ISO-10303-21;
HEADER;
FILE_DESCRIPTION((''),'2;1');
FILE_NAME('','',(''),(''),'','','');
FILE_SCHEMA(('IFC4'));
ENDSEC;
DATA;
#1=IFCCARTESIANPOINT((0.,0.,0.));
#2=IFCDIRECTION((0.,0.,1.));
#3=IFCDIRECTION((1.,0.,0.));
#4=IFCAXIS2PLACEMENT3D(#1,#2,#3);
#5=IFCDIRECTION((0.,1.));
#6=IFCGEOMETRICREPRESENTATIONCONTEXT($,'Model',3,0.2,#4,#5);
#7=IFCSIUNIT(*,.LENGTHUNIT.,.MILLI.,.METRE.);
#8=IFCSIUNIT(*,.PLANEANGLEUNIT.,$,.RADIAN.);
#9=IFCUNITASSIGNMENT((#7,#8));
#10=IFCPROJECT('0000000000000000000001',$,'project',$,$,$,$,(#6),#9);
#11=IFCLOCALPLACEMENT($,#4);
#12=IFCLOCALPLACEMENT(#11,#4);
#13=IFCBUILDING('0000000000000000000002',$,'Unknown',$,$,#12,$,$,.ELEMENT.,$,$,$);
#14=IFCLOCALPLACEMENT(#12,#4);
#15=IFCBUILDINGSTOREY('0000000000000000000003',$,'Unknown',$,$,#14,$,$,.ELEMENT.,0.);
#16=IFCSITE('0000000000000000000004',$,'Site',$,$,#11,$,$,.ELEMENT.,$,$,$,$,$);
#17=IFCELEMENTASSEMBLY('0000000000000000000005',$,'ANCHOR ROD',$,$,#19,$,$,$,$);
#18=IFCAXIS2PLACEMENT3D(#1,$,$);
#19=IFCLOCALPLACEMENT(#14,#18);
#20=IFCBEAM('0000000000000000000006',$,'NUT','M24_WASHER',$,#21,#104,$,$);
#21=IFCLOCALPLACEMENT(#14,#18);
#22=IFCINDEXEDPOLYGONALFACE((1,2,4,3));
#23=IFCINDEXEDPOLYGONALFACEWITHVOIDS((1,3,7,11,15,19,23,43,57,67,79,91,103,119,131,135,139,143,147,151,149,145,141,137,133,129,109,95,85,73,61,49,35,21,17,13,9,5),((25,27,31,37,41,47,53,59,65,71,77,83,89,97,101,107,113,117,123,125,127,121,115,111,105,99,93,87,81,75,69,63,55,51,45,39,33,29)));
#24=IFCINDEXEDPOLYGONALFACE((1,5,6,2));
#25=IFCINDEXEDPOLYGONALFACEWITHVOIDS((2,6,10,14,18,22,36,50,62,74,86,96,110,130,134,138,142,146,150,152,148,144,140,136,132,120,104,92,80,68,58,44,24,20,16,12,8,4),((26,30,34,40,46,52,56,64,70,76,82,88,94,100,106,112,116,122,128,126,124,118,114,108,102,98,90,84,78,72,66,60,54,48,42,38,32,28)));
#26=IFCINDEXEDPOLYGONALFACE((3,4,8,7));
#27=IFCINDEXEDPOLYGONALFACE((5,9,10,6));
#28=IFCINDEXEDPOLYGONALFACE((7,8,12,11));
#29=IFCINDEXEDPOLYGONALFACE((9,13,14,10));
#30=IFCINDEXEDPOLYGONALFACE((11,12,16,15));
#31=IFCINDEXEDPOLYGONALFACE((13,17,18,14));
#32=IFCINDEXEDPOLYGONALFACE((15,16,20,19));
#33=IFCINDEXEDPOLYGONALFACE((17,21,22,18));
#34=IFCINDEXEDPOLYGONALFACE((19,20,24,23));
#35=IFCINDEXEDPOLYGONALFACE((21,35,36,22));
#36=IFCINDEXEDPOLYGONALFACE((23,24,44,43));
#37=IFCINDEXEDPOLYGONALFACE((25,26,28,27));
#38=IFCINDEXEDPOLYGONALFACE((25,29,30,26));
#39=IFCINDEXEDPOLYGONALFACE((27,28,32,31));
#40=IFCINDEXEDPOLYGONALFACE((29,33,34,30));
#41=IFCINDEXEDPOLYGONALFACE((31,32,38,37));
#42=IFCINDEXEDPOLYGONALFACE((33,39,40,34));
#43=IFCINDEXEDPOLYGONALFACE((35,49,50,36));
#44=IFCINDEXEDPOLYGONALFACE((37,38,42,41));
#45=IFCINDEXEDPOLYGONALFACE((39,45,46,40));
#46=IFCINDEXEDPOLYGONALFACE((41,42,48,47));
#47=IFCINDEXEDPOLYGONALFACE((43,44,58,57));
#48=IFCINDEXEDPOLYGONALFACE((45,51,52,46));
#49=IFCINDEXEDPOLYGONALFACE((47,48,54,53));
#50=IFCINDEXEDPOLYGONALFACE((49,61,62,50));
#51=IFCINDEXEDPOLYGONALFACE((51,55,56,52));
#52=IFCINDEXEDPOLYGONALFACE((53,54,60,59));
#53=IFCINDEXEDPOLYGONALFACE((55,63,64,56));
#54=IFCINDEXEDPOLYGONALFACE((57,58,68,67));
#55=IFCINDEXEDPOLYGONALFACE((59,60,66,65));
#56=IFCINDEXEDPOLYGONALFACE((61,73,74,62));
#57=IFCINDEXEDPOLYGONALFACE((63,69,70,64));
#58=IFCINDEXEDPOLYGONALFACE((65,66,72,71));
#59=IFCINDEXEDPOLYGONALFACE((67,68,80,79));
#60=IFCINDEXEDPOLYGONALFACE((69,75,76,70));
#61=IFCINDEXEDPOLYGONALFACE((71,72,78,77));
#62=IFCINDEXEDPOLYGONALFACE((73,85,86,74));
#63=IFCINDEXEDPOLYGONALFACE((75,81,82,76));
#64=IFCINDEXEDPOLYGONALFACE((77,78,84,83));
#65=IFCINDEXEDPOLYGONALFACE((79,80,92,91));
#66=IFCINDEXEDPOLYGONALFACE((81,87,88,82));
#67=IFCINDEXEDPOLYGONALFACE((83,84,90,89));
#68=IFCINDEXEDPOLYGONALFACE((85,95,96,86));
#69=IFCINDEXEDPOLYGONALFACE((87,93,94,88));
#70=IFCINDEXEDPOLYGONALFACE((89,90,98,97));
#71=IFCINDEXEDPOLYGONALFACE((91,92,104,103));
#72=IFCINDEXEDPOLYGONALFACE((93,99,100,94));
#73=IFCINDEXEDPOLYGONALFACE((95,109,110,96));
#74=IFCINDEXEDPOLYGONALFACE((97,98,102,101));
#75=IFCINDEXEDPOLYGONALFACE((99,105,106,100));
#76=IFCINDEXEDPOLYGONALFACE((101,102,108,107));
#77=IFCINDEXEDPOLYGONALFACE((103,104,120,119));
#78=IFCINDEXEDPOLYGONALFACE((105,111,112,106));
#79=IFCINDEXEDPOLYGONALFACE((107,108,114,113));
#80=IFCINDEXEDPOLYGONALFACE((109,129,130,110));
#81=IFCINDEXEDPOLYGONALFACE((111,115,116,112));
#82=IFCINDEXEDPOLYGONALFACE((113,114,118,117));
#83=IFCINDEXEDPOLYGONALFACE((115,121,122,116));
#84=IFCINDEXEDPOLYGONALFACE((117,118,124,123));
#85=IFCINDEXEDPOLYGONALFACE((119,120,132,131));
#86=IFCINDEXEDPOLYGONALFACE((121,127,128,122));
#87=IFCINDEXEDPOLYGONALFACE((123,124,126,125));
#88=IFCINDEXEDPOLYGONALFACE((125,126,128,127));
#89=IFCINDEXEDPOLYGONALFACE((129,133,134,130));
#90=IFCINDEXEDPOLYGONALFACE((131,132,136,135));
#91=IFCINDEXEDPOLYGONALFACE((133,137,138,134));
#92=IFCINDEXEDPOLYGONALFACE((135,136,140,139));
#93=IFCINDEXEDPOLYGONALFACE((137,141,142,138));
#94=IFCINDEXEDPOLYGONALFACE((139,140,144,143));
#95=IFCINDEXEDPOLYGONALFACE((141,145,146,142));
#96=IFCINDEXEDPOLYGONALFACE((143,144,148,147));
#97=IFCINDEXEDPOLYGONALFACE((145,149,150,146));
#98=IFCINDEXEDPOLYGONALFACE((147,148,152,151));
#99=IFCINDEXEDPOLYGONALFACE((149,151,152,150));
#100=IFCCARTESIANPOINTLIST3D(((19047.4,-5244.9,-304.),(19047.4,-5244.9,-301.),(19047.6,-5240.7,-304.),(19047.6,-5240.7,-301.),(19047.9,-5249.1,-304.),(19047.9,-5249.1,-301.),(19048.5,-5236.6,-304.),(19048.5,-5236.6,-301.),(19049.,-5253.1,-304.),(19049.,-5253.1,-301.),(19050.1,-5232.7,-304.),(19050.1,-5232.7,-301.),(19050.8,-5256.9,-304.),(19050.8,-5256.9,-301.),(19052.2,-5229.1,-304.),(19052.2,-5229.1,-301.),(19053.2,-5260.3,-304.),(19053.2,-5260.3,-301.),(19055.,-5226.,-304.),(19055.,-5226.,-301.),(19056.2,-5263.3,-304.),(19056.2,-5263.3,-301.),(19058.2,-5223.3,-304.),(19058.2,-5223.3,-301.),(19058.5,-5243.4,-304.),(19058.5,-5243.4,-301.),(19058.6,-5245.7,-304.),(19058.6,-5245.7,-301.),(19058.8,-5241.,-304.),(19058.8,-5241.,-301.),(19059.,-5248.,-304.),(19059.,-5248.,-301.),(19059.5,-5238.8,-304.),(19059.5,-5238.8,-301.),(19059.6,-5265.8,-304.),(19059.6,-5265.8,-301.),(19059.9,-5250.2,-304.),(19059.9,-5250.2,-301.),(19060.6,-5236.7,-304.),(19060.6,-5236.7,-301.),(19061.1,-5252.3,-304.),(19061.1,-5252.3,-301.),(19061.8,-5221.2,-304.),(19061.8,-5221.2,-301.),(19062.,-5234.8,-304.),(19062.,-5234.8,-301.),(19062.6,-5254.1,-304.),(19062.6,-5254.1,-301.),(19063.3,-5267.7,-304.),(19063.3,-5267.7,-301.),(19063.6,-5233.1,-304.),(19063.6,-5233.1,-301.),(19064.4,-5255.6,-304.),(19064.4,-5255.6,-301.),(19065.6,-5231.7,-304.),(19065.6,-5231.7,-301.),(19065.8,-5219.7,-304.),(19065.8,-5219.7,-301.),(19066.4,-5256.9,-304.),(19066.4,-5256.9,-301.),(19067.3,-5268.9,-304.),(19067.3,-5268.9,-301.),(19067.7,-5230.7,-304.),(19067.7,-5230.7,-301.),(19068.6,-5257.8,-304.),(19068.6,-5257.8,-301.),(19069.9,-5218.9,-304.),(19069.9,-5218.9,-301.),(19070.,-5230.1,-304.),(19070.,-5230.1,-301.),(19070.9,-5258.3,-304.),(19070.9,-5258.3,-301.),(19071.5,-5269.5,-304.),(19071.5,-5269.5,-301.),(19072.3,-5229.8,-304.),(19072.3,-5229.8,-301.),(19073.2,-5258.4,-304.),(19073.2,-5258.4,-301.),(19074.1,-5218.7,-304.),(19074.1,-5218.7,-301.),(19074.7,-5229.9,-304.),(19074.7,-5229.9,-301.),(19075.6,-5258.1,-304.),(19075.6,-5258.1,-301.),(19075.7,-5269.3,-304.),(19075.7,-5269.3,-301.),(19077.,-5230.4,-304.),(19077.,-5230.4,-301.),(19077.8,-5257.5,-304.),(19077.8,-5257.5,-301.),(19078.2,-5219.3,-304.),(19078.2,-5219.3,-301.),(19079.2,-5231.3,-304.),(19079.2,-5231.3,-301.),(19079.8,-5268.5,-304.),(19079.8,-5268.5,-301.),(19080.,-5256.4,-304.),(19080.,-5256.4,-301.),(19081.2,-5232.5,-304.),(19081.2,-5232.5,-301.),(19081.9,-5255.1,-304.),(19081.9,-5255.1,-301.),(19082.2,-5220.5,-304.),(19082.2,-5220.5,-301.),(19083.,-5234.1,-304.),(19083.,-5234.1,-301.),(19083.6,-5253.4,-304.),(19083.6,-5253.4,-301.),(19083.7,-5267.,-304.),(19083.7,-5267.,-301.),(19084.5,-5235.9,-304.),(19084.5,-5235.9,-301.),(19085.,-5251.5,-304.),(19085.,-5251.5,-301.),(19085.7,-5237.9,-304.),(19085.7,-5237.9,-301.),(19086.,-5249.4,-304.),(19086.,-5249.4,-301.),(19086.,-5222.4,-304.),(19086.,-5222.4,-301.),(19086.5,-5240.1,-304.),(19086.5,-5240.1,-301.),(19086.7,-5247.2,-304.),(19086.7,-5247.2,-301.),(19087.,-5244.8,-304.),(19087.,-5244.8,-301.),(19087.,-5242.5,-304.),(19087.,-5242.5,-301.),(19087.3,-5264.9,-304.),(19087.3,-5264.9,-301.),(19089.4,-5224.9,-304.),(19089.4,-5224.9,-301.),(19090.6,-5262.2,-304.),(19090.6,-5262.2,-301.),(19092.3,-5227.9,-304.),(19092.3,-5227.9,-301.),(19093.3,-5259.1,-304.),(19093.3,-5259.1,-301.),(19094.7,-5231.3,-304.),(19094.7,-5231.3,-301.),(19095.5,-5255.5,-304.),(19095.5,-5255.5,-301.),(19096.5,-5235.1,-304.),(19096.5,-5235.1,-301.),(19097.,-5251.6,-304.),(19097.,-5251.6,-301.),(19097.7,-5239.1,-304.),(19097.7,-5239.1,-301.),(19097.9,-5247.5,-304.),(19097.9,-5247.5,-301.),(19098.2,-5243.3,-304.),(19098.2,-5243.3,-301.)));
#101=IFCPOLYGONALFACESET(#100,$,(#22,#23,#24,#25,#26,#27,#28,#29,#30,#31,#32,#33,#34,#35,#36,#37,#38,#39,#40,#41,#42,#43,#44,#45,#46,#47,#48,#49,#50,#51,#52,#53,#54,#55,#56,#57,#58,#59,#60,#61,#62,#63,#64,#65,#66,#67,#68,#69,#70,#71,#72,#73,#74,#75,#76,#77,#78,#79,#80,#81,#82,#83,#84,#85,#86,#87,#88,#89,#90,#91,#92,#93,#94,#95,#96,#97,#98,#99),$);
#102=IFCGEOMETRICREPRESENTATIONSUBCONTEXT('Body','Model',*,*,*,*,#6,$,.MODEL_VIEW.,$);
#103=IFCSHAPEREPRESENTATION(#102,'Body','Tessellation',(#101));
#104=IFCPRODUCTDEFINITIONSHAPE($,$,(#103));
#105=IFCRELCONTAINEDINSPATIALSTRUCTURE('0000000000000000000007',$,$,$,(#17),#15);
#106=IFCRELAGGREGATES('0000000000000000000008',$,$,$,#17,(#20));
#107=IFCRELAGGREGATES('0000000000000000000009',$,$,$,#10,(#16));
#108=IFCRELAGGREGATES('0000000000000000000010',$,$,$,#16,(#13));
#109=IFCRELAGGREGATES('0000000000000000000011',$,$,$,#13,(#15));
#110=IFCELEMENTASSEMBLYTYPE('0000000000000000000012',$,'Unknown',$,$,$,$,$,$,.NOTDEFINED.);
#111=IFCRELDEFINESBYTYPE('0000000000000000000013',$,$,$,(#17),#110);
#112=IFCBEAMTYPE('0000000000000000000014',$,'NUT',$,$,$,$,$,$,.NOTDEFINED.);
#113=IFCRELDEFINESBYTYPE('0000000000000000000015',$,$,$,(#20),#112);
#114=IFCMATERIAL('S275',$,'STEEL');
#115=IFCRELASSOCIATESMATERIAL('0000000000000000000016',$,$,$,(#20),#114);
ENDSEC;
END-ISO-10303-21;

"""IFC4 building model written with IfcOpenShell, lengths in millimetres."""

from ifc_helpers import new_model, si_unit, direction, frame, origin_with_axes, place, context, subcontext, project, spatial, polyline, outline, extrude, material, material_profile, profile_set, profile_usage, type_object, element, aggregate, save


model = new_model("IFC4")

# Units and contexts
model_context = context("Model", 3, precision=0.2, world=origin_with_axes(), true_north=direction((0.0, 1.0)))
body_context = subcontext(model_context, "Body", "Model", "MODEL_VIEW")
ifc_project = project(units=[si_unit("LENGTHUNIT", "METRE", prefix="MILLI"), si_unit("PLANEANGLEUNIT", "RADIAN")], contexts=[model_context])

# Site, building, storey
site_placement = place(None, origin_with_axes())
site = spatial("IfcSite", under=ifc_project, at=site_placement, Name="Site", CompositionType="ELEMENT")
building_placement = place(site_placement, origin_with_axes())
building = spatial("IfcBuilding", under=site, at=building_placement, Name="Unknown", CompositionType="ELEMENT")
storey_placement = place(building_placement, origin_with_axes())
storey = spatial("IfcBuildingStorey", under=building, at=storey_placement, Name="Unknown", CompositionType="ELEMENT", Elevation=0.0)

# Element assembly, beam
element_assembly_type = type_object("IfcElementAssemblyType", Name="Unknown", PredefinedType="NOTDEFINED")
assembly_1_placement = place(storey_placement, frame((19072.8, -5244.1, -261.0), z_axis=(0.054389, 0.99852, 0.0), x_axis=(0.0, 0.0, -1.0)))
assembly_1 = element("IfcElementAssembly", 1, at=assembly_1_placement, inside=storey, type_object=element_assembly_type, Name="ANCHOR ROD")
ifc_material_1 = material(Name="S275", Category="STEEL")
ifc_material_profile_1 = material_profile(ifc_material_1, outline(polyline([(25.4, 0.0), (25.1, 4.2), (24.0, 8.2), (22.3, 12.1), (20.0, 15.6), (17.2, 18.7), (13.9, 21.3), (10.2, 23.3), (6.2, 24.6), (2.1, 25.3), (-2.1, 25.3), (-6.2, 24.6), (-10.2, 23.3), (-13.9, 21.3), (-17.2, 18.7), (-20.0, 15.6), (-22.3, 12.1), (-24.0, 8.2), (-25.1, 4.2), (-25.4, 0.0), (-25.1, -4.2), (-24.0, -8.2), (-22.3, -12.1), (-20.0, -15.6), (-17.2, -18.7), (-13.9, -21.3), (-10.2, -23.3), (-6.2, -24.6), (-2.1, -25.3), (2.1, -25.3), (6.2, -24.6), (10.2, -23.3), (13.9, -21.3), (17.2, -18.7), (20.0, -15.6), (22.3, -12.1), (24.0, -8.2), (25.1, -4.2), (25.4, 0.0)]), holes=[polyline([(0.0, 14.3), (2.4, 14.1), (4.6, 13.5), (6.8, 12.6), (8.8, 11.3), (10.5, 9.7), (12.0, 7.8), (13.1, 5.7), (13.9, 3.5), (14.2, 1.2), (14.2, -1.2), (13.9, -3.5), (13.1, -5.7), (12.0, -7.8), (10.5, -9.7), (8.8, -11.3), (6.8, -12.6), (4.6, -13.5), (2.4, -14.1), (0.0, -14.3), (-2.4, -14.1), (-4.6, -13.5), (-6.8, -12.6), (-8.8, -11.3), (-10.5, -9.7), (-12.0, -7.8), (-13.1, -5.7), (-13.9, -3.5), (-14.2, -1.2), (-14.2, 1.2), (-13.9, 3.5), (-13.1, 5.7), (-12.0, 7.8), (-10.5, 9.7), (-8.8, 11.3), (-6.8, 12.6), (-4.6, 13.5), (-2.4, 14.1), (0.0, 14.3)])]), Name="M24_WASHER")
ifc_profile_set_1 = profile_set([ifc_material_profile_1])
ifc_profile_usage_1 = profile_usage(ifc_profile_set_1, cardinal=5)
beam_type_1 = type_object("IfcBeamType", Name="NUT", PredefinedType="NOTDEFINED")
beam_1_placement = place(assembly_1_placement, frame((40.0, 0.0, 0.0), z_axis=(0.0, 0.003456, 0.999994), x_axis=(1.0, 0.0, 0.0)))
beam_1 = element("IfcBeam", 2, at=beam_1_placement, type_object=beam_type_1, material=ifc_profile_usage_1, Name="NUT", Description="M24_WASHER", context=body_context, shape_type="SolidModel", body=[
    extrude(outline(polyline([(25.4, 0.0), (25.1, 4.2), (24.0, 8.2), (22.3, 12.1), (20.0, 15.6), (17.2, 18.7), (13.9, 21.3), (10.2, 23.3), (6.2, 24.6), (2.1, 25.3), (-2.1, 25.3), (-6.2, 24.6), (-10.2, 23.3), (-13.9, 21.3), (-17.2, 18.7), (-20.0, 15.6), (-22.3, 12.1), (-24.0, 8.2), (-25.1, 4.2), (-25.4, 0.0), (-25.1, -4.2), (-24.0, -8.2), (-22.3, -12.1), (-20.0, -15.6), (-17.2, -18.7), (-13.9, -21.3), (-10.2, -23.3), (-6.2, -24.6), (-2.1, -25.3), (2.1, -25.3), (6.2, -24.6), (10.2, -23.3), (13.9, -21.3), (17.2, -18.7), (20.0, -15.6), (22.3, -12.1), (24.0, -8.2), (25.1, -4.2), (25.4, 0.0)]), holes=[polyline([(0.0, 14.3), (2.4, 14.1), (4.6, 13.5), (6.8, 12.6), (8.8, 11.3), (10.5, 9.7), (12.0, 7.8), (13.1, 5.7), (13.9, 3.5), (14.2, 1.2), (14.2, -1.2), (13.9, -3.5), (13.1, -5.7), (12.0, -7.8), (10.5, -9.7), (8.8, -11.3), (6.8, -12.6), (4.6, -13.5), (2.4, -14.1), (0.0, -14.3), (-2.4, -14.1), (-4.6, -13.5), (-6.8, -12.6), (-8.8, -11.3), (-10.5, -9.7), (-12.0, -7.8), (-13.1, -5.7), (-13.9, -3.5), (-14.2, -1.2), (-14.2, 1.2), (-13.9, 3.5), (-13.1, 5.7), (-12.0, 7.8), (-10.5, 9.7), (-8.8, 11.3), (-6.8, 12.6), (-4.6, 13.5), (-2.4, 14.1), (0.0, 14.3)])]), frame((0.0, 0.0, 0.0), z_axis=(-1.0, 0.0, 0.0), x_axis=(0.0, 0.0, 1.0)), (0.0, 0.0, -1.0), 3.0),
])

aggregate(assembly_1, [beam_1])

save(model, "model.ifc")
